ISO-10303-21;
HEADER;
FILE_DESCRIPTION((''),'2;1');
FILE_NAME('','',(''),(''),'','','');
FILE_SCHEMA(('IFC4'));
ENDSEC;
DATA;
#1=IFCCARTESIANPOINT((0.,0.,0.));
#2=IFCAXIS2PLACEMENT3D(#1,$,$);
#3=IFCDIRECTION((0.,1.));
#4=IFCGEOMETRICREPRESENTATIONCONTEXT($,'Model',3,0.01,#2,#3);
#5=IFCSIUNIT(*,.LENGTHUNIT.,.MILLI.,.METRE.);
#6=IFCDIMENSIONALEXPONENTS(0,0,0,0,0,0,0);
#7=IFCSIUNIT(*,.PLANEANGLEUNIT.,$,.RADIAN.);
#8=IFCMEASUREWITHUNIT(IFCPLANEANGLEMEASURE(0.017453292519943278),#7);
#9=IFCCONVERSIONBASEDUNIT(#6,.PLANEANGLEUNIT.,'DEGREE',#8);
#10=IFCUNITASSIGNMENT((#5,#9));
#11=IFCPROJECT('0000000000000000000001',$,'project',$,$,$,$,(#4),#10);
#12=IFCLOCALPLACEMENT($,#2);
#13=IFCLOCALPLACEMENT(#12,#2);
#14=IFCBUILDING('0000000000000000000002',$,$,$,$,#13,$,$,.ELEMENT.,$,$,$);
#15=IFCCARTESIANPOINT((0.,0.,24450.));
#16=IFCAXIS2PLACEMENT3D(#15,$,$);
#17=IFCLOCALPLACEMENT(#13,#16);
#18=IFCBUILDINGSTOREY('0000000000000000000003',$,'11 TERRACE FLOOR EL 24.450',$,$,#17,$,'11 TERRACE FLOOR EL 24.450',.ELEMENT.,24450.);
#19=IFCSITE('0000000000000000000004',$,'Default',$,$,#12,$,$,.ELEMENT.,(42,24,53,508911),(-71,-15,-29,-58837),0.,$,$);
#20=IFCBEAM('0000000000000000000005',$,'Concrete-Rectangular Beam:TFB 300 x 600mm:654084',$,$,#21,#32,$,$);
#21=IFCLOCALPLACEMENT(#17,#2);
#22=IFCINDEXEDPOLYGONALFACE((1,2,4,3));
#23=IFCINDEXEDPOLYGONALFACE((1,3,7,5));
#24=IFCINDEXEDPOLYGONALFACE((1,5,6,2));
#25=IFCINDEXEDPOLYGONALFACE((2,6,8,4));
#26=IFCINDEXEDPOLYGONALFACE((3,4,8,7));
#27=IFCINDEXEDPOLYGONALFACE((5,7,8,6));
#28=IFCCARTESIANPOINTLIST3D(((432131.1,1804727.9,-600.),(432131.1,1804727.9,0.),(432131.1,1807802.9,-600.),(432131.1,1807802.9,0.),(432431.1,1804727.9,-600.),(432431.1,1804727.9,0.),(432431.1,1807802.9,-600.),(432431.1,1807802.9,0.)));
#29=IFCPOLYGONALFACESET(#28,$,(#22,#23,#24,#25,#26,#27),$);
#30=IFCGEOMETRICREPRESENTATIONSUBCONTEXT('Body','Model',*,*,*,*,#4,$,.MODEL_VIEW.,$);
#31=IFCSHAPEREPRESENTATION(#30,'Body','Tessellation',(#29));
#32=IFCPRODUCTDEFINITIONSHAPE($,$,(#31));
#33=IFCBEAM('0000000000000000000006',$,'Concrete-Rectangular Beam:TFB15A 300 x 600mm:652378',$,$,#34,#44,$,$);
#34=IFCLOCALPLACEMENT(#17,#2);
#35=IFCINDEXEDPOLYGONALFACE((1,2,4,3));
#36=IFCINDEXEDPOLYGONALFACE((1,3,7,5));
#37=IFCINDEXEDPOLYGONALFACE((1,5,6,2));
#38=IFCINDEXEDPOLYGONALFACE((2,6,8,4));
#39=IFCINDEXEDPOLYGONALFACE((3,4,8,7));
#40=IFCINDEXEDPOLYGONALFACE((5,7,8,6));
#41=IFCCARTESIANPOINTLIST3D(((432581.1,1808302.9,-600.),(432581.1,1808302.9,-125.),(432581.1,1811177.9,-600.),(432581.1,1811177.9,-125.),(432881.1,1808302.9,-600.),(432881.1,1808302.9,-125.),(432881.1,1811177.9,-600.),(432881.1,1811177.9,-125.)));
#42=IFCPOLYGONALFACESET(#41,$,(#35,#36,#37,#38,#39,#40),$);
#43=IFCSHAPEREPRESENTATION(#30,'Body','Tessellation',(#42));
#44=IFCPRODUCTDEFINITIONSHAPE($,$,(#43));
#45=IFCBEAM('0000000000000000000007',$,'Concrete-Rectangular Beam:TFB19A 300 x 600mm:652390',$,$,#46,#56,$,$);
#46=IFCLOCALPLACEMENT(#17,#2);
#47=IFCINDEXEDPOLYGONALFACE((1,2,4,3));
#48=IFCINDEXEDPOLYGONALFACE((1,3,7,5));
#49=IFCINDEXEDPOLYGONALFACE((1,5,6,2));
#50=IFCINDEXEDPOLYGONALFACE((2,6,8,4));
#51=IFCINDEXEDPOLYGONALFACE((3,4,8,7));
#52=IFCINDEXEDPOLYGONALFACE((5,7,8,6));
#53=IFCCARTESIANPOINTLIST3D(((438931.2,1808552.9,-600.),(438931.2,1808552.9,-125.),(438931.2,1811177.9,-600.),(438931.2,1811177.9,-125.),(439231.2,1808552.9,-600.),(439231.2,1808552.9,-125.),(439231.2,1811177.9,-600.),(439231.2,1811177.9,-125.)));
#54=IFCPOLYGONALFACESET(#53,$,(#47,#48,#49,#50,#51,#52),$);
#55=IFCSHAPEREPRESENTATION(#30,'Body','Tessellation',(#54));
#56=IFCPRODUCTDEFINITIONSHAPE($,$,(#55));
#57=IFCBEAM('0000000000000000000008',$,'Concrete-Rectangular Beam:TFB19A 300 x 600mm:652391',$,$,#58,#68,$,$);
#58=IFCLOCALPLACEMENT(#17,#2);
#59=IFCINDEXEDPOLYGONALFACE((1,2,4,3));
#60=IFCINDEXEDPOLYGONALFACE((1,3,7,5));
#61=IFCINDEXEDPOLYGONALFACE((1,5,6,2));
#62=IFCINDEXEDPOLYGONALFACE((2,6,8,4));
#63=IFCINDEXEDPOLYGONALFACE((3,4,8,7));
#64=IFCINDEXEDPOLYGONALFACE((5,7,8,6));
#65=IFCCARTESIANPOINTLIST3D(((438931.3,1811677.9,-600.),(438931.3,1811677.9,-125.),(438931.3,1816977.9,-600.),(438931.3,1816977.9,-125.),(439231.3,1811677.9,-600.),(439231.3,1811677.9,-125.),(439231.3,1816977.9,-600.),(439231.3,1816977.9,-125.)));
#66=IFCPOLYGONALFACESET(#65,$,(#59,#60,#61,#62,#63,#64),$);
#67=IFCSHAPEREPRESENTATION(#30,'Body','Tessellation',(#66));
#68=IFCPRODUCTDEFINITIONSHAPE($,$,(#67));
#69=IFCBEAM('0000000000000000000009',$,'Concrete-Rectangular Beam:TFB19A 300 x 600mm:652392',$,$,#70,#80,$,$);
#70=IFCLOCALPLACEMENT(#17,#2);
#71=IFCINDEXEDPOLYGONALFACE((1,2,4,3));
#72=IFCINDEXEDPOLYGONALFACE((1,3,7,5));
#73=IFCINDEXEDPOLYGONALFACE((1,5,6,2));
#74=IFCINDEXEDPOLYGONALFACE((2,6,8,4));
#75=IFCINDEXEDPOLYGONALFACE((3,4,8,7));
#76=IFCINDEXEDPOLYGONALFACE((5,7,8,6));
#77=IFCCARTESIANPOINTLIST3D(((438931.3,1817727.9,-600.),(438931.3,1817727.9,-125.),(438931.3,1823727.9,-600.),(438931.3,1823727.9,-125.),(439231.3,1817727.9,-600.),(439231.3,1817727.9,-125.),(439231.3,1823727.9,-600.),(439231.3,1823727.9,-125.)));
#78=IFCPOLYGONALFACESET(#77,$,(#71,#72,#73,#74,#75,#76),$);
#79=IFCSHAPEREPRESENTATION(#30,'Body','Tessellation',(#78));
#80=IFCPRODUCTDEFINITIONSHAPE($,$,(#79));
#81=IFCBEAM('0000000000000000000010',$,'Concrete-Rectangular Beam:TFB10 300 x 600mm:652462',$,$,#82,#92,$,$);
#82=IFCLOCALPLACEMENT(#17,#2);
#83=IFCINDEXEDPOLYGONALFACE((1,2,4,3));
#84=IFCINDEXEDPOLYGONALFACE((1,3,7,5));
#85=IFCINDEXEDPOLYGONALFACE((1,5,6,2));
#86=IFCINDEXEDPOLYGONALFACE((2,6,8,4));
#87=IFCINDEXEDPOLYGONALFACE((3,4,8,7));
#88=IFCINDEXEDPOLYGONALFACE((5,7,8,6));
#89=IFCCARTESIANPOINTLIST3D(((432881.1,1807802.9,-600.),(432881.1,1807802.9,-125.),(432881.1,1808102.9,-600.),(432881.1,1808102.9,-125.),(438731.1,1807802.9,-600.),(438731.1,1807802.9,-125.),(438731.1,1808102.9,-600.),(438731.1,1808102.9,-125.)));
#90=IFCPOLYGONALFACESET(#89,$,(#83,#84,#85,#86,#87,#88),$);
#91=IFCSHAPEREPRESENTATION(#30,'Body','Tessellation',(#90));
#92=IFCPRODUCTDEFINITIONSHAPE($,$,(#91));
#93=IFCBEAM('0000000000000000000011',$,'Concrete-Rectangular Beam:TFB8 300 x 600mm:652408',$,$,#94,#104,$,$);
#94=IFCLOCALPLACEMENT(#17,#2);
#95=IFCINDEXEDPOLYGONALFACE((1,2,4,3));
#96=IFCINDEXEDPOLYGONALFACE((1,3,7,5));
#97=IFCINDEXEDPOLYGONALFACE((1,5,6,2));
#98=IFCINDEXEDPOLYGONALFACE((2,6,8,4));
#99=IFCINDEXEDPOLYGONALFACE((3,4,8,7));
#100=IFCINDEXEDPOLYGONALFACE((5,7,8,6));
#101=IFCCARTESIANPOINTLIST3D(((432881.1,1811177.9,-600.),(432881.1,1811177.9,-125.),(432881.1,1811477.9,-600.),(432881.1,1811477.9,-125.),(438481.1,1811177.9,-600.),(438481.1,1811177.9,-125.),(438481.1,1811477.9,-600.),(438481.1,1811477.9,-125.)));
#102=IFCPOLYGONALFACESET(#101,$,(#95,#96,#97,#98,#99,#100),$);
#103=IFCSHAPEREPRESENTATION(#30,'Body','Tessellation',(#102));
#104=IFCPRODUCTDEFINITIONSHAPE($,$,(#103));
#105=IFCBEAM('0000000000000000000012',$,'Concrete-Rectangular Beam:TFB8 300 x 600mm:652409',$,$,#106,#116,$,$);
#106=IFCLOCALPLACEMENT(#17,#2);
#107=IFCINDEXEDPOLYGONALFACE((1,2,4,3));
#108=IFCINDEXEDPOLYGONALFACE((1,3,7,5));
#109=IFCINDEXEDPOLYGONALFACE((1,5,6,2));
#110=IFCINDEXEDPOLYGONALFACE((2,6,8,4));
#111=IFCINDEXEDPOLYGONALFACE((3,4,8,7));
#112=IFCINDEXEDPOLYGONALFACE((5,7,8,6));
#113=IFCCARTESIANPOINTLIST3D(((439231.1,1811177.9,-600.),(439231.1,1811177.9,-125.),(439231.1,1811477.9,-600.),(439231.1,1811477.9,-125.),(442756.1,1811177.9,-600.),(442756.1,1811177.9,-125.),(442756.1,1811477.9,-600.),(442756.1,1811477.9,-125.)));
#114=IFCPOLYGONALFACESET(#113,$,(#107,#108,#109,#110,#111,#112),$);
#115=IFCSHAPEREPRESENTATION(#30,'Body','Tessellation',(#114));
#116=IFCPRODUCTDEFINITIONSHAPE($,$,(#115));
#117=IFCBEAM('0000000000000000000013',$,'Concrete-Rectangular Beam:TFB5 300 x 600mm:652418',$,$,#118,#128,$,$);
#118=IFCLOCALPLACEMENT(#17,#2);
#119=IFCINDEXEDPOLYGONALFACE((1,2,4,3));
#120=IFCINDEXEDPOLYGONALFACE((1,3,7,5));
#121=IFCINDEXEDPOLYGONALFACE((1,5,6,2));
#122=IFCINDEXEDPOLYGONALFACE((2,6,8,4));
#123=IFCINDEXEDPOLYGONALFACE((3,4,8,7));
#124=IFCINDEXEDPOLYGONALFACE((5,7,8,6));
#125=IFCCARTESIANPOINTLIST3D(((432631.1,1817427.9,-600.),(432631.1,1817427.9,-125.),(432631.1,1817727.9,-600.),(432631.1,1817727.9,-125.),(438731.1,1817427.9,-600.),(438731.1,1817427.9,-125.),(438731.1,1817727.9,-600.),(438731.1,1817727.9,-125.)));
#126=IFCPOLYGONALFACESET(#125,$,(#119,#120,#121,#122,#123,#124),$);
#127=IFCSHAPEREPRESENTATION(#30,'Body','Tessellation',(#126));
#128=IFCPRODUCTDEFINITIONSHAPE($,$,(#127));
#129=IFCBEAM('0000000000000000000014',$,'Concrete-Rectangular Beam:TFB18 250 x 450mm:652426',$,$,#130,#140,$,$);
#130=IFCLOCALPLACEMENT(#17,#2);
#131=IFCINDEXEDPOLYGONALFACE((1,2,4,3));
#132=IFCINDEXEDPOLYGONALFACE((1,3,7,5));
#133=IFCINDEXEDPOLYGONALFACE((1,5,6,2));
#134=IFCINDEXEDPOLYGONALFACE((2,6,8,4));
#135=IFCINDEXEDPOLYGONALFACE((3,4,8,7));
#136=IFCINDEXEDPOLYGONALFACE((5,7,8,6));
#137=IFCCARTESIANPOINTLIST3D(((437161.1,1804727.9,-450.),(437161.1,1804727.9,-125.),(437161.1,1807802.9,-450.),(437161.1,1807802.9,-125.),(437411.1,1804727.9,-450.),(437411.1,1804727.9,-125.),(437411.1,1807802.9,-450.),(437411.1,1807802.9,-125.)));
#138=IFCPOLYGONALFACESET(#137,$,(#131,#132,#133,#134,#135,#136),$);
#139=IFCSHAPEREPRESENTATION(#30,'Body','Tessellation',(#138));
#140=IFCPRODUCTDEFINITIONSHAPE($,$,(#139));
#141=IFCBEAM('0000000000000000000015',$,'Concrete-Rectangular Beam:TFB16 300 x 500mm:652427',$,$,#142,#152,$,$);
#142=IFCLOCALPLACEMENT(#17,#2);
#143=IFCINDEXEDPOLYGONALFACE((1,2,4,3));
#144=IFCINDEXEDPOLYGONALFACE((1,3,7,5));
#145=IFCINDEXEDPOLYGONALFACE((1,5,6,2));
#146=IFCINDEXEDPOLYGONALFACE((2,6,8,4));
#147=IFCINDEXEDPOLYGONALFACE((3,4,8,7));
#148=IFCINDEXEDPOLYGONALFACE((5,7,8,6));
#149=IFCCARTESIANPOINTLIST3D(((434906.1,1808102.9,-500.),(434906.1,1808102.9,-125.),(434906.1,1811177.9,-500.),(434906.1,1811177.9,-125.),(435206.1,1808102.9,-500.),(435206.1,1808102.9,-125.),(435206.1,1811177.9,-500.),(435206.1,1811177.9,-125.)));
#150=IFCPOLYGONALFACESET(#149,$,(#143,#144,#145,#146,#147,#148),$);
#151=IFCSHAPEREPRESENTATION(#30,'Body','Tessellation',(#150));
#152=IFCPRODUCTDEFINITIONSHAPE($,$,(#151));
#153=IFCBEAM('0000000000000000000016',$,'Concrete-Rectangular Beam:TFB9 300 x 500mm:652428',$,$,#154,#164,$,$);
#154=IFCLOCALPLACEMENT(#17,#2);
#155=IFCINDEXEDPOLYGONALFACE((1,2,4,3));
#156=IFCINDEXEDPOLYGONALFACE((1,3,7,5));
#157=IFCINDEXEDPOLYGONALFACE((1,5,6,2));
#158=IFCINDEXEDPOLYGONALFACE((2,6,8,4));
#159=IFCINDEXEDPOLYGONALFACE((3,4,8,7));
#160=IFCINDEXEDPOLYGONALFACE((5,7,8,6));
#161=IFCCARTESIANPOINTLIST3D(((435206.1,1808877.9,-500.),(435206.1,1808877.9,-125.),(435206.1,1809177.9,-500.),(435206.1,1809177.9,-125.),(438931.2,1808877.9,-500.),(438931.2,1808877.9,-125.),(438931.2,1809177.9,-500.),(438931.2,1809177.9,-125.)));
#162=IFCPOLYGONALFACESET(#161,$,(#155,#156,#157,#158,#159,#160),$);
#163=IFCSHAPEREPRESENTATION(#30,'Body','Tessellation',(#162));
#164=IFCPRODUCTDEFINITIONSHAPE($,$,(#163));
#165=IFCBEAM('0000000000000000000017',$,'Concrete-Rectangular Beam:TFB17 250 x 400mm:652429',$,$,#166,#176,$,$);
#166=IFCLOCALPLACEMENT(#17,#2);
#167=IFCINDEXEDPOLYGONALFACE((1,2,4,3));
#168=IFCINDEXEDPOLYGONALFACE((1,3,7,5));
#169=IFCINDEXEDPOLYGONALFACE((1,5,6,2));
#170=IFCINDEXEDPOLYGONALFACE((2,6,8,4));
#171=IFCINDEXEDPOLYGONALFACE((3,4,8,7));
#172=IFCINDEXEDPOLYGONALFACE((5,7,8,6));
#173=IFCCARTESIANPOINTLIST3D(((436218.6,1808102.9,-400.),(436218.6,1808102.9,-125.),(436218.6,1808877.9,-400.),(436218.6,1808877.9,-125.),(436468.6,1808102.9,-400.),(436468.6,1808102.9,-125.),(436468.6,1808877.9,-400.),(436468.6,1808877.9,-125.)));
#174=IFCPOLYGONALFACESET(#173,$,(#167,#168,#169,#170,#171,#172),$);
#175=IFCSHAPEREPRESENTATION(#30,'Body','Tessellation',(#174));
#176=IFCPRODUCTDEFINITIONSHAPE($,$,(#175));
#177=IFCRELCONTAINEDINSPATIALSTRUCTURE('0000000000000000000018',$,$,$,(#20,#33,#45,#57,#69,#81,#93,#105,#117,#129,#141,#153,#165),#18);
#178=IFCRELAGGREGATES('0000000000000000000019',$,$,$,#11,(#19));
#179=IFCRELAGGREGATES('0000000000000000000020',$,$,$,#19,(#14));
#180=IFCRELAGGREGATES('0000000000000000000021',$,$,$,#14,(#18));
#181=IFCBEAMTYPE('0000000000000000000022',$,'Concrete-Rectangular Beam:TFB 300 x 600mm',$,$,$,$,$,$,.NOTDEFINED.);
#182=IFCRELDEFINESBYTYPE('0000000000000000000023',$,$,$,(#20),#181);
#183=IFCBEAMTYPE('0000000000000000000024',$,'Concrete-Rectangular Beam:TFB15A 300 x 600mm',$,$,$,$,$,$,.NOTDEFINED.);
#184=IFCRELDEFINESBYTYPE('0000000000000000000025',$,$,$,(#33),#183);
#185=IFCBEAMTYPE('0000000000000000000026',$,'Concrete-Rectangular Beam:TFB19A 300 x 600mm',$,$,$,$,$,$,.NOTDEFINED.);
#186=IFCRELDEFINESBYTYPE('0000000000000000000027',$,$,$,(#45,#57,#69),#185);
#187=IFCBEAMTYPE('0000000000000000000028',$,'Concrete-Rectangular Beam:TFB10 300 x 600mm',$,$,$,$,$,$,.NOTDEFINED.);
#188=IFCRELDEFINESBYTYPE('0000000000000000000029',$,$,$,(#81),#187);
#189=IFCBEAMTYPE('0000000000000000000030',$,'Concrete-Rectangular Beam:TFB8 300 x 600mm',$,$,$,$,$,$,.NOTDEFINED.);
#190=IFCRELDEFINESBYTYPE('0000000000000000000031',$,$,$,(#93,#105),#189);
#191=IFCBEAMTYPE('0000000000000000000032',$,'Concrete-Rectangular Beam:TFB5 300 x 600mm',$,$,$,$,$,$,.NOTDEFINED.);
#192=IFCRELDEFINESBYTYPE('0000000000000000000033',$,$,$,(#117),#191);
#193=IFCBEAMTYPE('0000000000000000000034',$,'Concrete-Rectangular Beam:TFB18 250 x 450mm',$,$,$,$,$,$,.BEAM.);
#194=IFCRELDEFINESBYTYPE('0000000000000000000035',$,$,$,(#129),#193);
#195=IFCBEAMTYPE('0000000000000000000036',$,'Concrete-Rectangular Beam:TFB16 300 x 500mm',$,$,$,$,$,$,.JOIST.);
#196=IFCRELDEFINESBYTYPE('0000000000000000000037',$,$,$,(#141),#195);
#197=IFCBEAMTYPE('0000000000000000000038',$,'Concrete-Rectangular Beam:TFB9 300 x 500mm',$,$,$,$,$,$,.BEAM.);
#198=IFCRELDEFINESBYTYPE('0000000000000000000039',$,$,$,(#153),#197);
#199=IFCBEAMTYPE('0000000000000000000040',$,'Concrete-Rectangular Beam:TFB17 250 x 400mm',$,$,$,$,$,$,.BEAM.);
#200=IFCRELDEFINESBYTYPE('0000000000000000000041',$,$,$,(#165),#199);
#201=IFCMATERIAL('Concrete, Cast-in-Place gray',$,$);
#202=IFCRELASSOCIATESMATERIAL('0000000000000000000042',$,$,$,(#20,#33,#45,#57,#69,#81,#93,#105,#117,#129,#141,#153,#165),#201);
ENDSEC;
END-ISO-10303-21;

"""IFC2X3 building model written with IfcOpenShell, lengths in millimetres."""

from ifc_helpers import new_model, entity, si_unit, converted_unit, direction, frame, frame_2d, origin, origin_2d_with_axis, place, context, subcontext, project, spatial, rectangle, extrude, material, type_object, element, save


model = new_model("IFC2X3")

# Units and contexts
model_context = context("Model", 3, precision=0.01, world=origin(), true_north=direction((0.0, 1.0)))
body_context = subcontext(model_context, "Body", "Model", "MODEL_VIEW")
ifc_project = project(units=[si_unit("LENGTHUNIT", "METRE", prefix="MILLI"), converted_unit("PLANEANGLEUNIT", "DEGREE", entity("IfcPlaneAngleMeasure", 0.017453292519943278), si_unit("PLANEANGLEUNIT", "RADIAN"), dimensions=[0, 0, 0, 0, 0, 0, 0])], contexts=[model_context])

# Site, building, storey
site_placement = place(None, origin())
site = spatial("IfcSite", under=ifc_project, at=site_placement, Name="Default", CompositionType="ELEMENT", RefLatitude=(42, 24, 53, 508911), RefLongitude=(-71, -15, -29, -58837), RefElevation=0.0)
building_placement = place(site_placement, origin())
building = spatial("IfcBuilding", under=site, at=building_placement, CompositionType="ELEMENT")
storey_placement = place(building_placement, frame((0.0, 0.0, 24450.0)))
storey = spatial("IfcBuildingStorey", under=building, at=storey_placement, Name="11 TERRACE FLOOR EL 24.450", LongName="11 TERRACE FLOOR EL 24.450", CompositionType="ELEMENT", Elevation=24450.0)

# Beams
ifc_material = material(Name="Concrete, Cast-in-Place gray")
beam_type_1 = type_object("IfcBeamType", Name="Concrete-Rectangular Beam:TFB 300 x 600mm", PredefinedType="NOTDEFINED")
beam_1_placement = place(storey_placement, frame((432431.1, 1804727.9, 0.0), z_axis=(0.0, 0.0, 1.0), x_axis=(0.0, 1.0, 0.0)))
element("IfcBeam", 1, at=beam_1_placement, inside=storey, type_object=beam_type_1, material=ifc_material, Name="Concrete-Rectangular Beam:TFB 300 x 600mm:654084", context=body_context, shape_type="SweptSolid", body=[
    extrude(rectangle(XDim=600.0, YDim=300.0, at=origin_2d_with_axis()), frame((0.0, 150.0, -300.0), z_axis=(1.0, 0.0, 0.0), x_axis=(0.0, 0.0, -1.0)), (0.0, 0.0, 1.0), 3075.0),
])
beam_type_2 = type_object("IfcBeamType", Name="Concrete-Rectangular Beam:TFB15A 300 x 600mm", PredefinedType="NOTDEFINED")
beam_2_placement = place(storey_placement, frame((432881.1, 1808302.9, 0.0), z_axis=(0.0, 0.0, 1.0), x_axis=(0.0, 1.0, 0.0)))
element("IfcBeam", 2, at=beam_2_placement, inside=storey, type_object=beam_type_2, material=ifc_material, Name="Concrete-Rectangular Beam:TFB15A 300 x 600mm:652378", context=body_context, shape_type="SweptSolid", body=[
    extrude(rectangle(XDim=475.0, YDim=300.0, at=frame_2d((0.0, 0.0), x_axis=(1.0, 0.0))), frame((0.0, 150.0, -362.5), z_axis=(1.0, 0.0, 0.0), x_axis=(0.0, 0.0, -1.0)), (0.0, 0.0, 1.0), 2875.0),
])
beam_type_3 = type_object("IfcBeamType", Name="Concrete-Rectangular Beam:TFB19A 300 x 600mm", PredefinedType="NOTDEFINED")
beam_3_placement = place(storey_placement, frame((438931.2, 1808552.9, 0.0), z_axis=(0.0, 0.0, 1.0), x_axis=(0.0, 1.0, 0.0)))
element("IfcBeam", 3, at=beam_3_placement, inside=storey, type_object=beam_type_3, material=ifc_material, Name="Concrete-Rectangular Beam:TFB19A 300 x 600mm:652390", context=body_context, shape_type="SweptSolid", body=[
    extrude(rectangle(XDim=475.0, YDim=300.0, at=frame_2d((0.0, 0.0), x_axis=(1.0, 0.0))), frame((0.0, -150.0, -362.5), z_axis=(1.0, 0.0, 0.0), x_axis=(0.0, 0.0, -1.0)), (0.0, 0.0, 1.0), 2625.0),
])
beam_4_placement = place(storey_placement, frame((438931.3, 1811677.9, 0.0), z_axis=(0.0, 0.0, 1.0), x_axis=(0.0, 1.0, 0.0)))
element("IfcBeam", 4, at=beam_4_placement, inside=storey, type_object=beam_type_3, material=ifc_material, Name="Concrete-Rectangular Beam:TFB19A 300 x 600mm:652391", context=body_context, shape_type="SweptSolid", body=[
    extrude(rectangle(XDim=475.0, YDim=300.0, at=frame_2d((0.0, 0.0), x_axis=(1.0, 0.0))), frame((0.0, -150.0, -362.5), z_axis=(1.0, 0.0, 0.0), x_axis=(0.0, 0.0, -1.0)), (0.0, 0.0, 1.0), 5300.0),
])
beam_5_placement = place(storey_placement, frame((438931.3, 1817727.9, 0.0), z_axis=(0.0, 0.0, 1.0), x_axis=(0.0, 1.0, 0.0)))
element("IfcBeam", 5, at=beam_5_placement, inside=storey, type_object=beam_type_3, material=ifc_material, Name="Concrete-Rectangular Beam:TFB19A 300 x 600mm:652392", context=body_context, shape_type="SweptSolid", body=[
    extrude(rectangle(XDim=475.0, YDim=300.0, at=frame_2d((0.0, 0.0), x_axis=(1.0, 0.0))), frame((0.0, -150.0, -362.5), z_axis=(1.0, 0.0, 0.0), x_axis=(0.0, 0.0, -1.0)), (0.0, 0.0, 1.0), 6000.0),
])
beam_type_4 = type_object("IfcBeamType", Name="Concrete-Rectangular Beam:TFB10 300 x 600mm", PredefinedType="NOTDEFINED")
beam_6_placement = place(storey_placement, frame((432881.1, 1808102.9, 0.0)))
element("IfcBeam", 6, at=beam_6_placement, inside=storey, type_object=beam_type_4, material=ifc_material, Name="Concrete-Rectangular Beam:TFB10 300 x 600mm:652462", context=body_context, shape_type="SweptSolid", body=[
    extrude(rectangle(XDim=475.0, YDim=300.0, at=frame_2d((0.0, 0.0), x_axis=(1.0, 0.0))), frame((0.0, -150.0, -362.5), z_axis=(1.0, 0.0, 0.0), x_axis=(0.0, 0.0, -1.0)), (0.0, 0.0, 1.0), 5850.0),
])
beam_type_5 = type_object("IfcBeamType", Name="Concrete-Rectangular Beam:TFB8 300 x 600mm", PredefinedType="NOTDEFINED")
beam_7_placement = place(storey_placement, frame((432881.1, 1811177.9, 0.0)))
element("IfcBeam", 7, at=beam_7_placement, inside=storey, type_object=beam_type_5, material=ifc_material, Name="Concrete-Rectangular Beam:TFB8 300 x 600mm:652408", context=body_context, shape_type="SweptSolid", body=[
    extrude(rectangle(XDim=475.0, YDim=300.0, at=frame_2d((0.0, 0.0), x_axis=(1.0, 0.0))), frame((0.0, 150.0, -362.5), z_axis=(1.0, 0.0, 0.0), x_axis=(0.0, 0.0, -1.0)), (0.0, 0.0, 1.0), 5600.0),
])
beam_8_placement = place(storey_placement, frame((439231.1, 1811177.9, 0.0)))
element("IfcBeam", 8, at=beam_8_placement, inside=storey, type_object=beam_type_5, material=ifc_material, Name="Concrete-Rectangular Beam:TFB8 300 x 600mm:652409", context=body_context, shape_type="SweptSolid", body=[
    extrude(rectangle(XDim=475.0, YDim=300.0, at=frame_2d((0.0, 0.0), x_axis=(1.0, 0.0))), frame((0.0, 150.0, -362.5), z_axis=(1.0, 0.0, 0.0), x_axis=(0.0, 0.0, -1.0)), (0.0, 0.0, 1.0), 3525.0),
])
beam_type_6 = type_object("IfcBeamType", Name="Concrete-Rectangular Beam:TFB5 300 x 600mm", PredefinedType="NOTDEFINED")
beam_9_placement = place(storey_placement, frame((432631.1, 1817727.9, 0.0)))
element("IfcBeam", 9, at=beam_9_placement, inside=storey, type_object=beam_type_6, material=ifc_material, Name="Concrete-Rectangular Beam:TFB5 300 x 600mm:652418", context=body_context, shape_type="SweptSolid", body=[
    extrude(rectangle(XDim=475.0, YDim=300.0, at=frame_2d((0.0, 0.0), x_axis=(1.0, 0.0))), frame((0.0, -150.0, -362.5), z_axis=(1.0, 0.0, 0.0), x_axis=(0.0, 0.0, -1.0)), (0.0, 0.0, 1.0), 6100.0),
])
beam_type_7 = type_object("IfcBeamType", Name="Concrete-Rectangular Beam:TFB18 250 x 450mm", PredefinedType="BEAM")
beam_10_placement = place(storey_placement, frame((437161.1, 1807802.9, 0.0), z_axis=(0.0, 0.0, 1.0), x_axis=(0.0, -1.0, 0.0)))
element("IfcBeam", 10, at=beam_10_placement, inside=storey, type_object=beam_type_7, material=ifc_material, Name="Concrete-Rectangular Beam:TFB18 250 x 450mm:652426", context=body_context, shape_type="SweptSolid", body=[
    extrude(rectangle(XDim=325.0, YDim=250.0, at=frame_2d((0.0, 0.0), x_axis=(1.0, 0.0))), frame((0.0, 125.0, -287.5), z_axis=(1.0, 0.0, 0.0), x_axis=(0.0, 0.0, -1.0)), (0.0, 0.0, 1.0), 3075.0),
])
beam_type_8 = type_object("IfcBeamType", Name="Concrete-Rectangular Beam:TFB16 300 x 500mm", PredefinedType="JOIST")
beam_11_placement = place(storey_placement, frame((434906.1, 1811177.9, 0.0), z_axis=(0.0, 0.0, 1.0), x_axis=(0.0, -1.0, 0.0)))
element("IfcBeam", 11, at=beam_11_placement, inside=storey, type_object=beam_type_8, material=ifc_material, Name="Concrete-Rectangular Beam:TFB16 300 x 500mm:652427", context=body_context, shape_type="SweptSolid", body=[
    extrude(rectangle(XDim=375.0, YDim=300.0, at=frame_2d((0.0, 0.0), x_axis=(1.0, 0.0))), frame((0.0, 150.0, -312.5), z_axis=(1.0, 0.0, 0.0), x_axis=(0.0, 0.0, -1.0)), (0.0, 0.0, 1.0), 3075.0),
])
beam_type_9 = type_object("IfcBeamType", Name="Concrete-Rectangular Beam:TFB9 300 x 500mm", PredefinedType="BEAM")
beam_12_placement = place(storey_placement, frame((435206.1, 1808877.9, 0.0)))
element("IfcBeam", 12, at=beam_12_placement, inside=storey, type_object=beam_type_9, material=ifc_material, Name="Concrete-Rectangular Beam:TFB9 300 x 500mm:652428", context=body_context, shape_type="SweptSolid", body=[
    extrude(rectangle(XDim=375.0, YDim=300.0, at=frame_2d((0.0, 0.0), x_axis=(1.0, 0.0))), frame((0.0, 150.0, -312.5), z_axis=(1.0, 0.0, 0.0), x_axis=(0.0, 0.0, -1.0)), (0.0, 0.0, 1.0), 3725.1),
])
beam_type_10 = type_object("IfcBeamType", Name="Concrete-Rectangular Beam:TFB17 250 x 400mm", PredefinedType="BEAM")
beam_13_placement = place(storey_placement, frame((436218.6, 1808877.9, 0.0), z_axis=(0.0, 0.0, 1.0), x_axis=(0.0, -1.0, 0.0)))
element("IfcBeam", 13, at=beam_13_placement, inside=storey, type_object=beam_type_10, material=ifc_material, Name="Concrete-Rectangular Beam:TFB17 250 x 400mm:652429", context=body_context, shape_type="SweptSolid", body=[
    extrude(rectangle(XDim=275.0, YDim=250.0, at=frame_2d((0.0, 0.0), x_axis=(1.0, 0.0))), frame((0.0, 125.0, -262.5), z_axis=(1.0, 0.0, 0.0), x_axis=(0.0, 0.0, -1.0)), (0.0, 0.0, 1.0), 775.0),
])

save(model, "model.ifc")
